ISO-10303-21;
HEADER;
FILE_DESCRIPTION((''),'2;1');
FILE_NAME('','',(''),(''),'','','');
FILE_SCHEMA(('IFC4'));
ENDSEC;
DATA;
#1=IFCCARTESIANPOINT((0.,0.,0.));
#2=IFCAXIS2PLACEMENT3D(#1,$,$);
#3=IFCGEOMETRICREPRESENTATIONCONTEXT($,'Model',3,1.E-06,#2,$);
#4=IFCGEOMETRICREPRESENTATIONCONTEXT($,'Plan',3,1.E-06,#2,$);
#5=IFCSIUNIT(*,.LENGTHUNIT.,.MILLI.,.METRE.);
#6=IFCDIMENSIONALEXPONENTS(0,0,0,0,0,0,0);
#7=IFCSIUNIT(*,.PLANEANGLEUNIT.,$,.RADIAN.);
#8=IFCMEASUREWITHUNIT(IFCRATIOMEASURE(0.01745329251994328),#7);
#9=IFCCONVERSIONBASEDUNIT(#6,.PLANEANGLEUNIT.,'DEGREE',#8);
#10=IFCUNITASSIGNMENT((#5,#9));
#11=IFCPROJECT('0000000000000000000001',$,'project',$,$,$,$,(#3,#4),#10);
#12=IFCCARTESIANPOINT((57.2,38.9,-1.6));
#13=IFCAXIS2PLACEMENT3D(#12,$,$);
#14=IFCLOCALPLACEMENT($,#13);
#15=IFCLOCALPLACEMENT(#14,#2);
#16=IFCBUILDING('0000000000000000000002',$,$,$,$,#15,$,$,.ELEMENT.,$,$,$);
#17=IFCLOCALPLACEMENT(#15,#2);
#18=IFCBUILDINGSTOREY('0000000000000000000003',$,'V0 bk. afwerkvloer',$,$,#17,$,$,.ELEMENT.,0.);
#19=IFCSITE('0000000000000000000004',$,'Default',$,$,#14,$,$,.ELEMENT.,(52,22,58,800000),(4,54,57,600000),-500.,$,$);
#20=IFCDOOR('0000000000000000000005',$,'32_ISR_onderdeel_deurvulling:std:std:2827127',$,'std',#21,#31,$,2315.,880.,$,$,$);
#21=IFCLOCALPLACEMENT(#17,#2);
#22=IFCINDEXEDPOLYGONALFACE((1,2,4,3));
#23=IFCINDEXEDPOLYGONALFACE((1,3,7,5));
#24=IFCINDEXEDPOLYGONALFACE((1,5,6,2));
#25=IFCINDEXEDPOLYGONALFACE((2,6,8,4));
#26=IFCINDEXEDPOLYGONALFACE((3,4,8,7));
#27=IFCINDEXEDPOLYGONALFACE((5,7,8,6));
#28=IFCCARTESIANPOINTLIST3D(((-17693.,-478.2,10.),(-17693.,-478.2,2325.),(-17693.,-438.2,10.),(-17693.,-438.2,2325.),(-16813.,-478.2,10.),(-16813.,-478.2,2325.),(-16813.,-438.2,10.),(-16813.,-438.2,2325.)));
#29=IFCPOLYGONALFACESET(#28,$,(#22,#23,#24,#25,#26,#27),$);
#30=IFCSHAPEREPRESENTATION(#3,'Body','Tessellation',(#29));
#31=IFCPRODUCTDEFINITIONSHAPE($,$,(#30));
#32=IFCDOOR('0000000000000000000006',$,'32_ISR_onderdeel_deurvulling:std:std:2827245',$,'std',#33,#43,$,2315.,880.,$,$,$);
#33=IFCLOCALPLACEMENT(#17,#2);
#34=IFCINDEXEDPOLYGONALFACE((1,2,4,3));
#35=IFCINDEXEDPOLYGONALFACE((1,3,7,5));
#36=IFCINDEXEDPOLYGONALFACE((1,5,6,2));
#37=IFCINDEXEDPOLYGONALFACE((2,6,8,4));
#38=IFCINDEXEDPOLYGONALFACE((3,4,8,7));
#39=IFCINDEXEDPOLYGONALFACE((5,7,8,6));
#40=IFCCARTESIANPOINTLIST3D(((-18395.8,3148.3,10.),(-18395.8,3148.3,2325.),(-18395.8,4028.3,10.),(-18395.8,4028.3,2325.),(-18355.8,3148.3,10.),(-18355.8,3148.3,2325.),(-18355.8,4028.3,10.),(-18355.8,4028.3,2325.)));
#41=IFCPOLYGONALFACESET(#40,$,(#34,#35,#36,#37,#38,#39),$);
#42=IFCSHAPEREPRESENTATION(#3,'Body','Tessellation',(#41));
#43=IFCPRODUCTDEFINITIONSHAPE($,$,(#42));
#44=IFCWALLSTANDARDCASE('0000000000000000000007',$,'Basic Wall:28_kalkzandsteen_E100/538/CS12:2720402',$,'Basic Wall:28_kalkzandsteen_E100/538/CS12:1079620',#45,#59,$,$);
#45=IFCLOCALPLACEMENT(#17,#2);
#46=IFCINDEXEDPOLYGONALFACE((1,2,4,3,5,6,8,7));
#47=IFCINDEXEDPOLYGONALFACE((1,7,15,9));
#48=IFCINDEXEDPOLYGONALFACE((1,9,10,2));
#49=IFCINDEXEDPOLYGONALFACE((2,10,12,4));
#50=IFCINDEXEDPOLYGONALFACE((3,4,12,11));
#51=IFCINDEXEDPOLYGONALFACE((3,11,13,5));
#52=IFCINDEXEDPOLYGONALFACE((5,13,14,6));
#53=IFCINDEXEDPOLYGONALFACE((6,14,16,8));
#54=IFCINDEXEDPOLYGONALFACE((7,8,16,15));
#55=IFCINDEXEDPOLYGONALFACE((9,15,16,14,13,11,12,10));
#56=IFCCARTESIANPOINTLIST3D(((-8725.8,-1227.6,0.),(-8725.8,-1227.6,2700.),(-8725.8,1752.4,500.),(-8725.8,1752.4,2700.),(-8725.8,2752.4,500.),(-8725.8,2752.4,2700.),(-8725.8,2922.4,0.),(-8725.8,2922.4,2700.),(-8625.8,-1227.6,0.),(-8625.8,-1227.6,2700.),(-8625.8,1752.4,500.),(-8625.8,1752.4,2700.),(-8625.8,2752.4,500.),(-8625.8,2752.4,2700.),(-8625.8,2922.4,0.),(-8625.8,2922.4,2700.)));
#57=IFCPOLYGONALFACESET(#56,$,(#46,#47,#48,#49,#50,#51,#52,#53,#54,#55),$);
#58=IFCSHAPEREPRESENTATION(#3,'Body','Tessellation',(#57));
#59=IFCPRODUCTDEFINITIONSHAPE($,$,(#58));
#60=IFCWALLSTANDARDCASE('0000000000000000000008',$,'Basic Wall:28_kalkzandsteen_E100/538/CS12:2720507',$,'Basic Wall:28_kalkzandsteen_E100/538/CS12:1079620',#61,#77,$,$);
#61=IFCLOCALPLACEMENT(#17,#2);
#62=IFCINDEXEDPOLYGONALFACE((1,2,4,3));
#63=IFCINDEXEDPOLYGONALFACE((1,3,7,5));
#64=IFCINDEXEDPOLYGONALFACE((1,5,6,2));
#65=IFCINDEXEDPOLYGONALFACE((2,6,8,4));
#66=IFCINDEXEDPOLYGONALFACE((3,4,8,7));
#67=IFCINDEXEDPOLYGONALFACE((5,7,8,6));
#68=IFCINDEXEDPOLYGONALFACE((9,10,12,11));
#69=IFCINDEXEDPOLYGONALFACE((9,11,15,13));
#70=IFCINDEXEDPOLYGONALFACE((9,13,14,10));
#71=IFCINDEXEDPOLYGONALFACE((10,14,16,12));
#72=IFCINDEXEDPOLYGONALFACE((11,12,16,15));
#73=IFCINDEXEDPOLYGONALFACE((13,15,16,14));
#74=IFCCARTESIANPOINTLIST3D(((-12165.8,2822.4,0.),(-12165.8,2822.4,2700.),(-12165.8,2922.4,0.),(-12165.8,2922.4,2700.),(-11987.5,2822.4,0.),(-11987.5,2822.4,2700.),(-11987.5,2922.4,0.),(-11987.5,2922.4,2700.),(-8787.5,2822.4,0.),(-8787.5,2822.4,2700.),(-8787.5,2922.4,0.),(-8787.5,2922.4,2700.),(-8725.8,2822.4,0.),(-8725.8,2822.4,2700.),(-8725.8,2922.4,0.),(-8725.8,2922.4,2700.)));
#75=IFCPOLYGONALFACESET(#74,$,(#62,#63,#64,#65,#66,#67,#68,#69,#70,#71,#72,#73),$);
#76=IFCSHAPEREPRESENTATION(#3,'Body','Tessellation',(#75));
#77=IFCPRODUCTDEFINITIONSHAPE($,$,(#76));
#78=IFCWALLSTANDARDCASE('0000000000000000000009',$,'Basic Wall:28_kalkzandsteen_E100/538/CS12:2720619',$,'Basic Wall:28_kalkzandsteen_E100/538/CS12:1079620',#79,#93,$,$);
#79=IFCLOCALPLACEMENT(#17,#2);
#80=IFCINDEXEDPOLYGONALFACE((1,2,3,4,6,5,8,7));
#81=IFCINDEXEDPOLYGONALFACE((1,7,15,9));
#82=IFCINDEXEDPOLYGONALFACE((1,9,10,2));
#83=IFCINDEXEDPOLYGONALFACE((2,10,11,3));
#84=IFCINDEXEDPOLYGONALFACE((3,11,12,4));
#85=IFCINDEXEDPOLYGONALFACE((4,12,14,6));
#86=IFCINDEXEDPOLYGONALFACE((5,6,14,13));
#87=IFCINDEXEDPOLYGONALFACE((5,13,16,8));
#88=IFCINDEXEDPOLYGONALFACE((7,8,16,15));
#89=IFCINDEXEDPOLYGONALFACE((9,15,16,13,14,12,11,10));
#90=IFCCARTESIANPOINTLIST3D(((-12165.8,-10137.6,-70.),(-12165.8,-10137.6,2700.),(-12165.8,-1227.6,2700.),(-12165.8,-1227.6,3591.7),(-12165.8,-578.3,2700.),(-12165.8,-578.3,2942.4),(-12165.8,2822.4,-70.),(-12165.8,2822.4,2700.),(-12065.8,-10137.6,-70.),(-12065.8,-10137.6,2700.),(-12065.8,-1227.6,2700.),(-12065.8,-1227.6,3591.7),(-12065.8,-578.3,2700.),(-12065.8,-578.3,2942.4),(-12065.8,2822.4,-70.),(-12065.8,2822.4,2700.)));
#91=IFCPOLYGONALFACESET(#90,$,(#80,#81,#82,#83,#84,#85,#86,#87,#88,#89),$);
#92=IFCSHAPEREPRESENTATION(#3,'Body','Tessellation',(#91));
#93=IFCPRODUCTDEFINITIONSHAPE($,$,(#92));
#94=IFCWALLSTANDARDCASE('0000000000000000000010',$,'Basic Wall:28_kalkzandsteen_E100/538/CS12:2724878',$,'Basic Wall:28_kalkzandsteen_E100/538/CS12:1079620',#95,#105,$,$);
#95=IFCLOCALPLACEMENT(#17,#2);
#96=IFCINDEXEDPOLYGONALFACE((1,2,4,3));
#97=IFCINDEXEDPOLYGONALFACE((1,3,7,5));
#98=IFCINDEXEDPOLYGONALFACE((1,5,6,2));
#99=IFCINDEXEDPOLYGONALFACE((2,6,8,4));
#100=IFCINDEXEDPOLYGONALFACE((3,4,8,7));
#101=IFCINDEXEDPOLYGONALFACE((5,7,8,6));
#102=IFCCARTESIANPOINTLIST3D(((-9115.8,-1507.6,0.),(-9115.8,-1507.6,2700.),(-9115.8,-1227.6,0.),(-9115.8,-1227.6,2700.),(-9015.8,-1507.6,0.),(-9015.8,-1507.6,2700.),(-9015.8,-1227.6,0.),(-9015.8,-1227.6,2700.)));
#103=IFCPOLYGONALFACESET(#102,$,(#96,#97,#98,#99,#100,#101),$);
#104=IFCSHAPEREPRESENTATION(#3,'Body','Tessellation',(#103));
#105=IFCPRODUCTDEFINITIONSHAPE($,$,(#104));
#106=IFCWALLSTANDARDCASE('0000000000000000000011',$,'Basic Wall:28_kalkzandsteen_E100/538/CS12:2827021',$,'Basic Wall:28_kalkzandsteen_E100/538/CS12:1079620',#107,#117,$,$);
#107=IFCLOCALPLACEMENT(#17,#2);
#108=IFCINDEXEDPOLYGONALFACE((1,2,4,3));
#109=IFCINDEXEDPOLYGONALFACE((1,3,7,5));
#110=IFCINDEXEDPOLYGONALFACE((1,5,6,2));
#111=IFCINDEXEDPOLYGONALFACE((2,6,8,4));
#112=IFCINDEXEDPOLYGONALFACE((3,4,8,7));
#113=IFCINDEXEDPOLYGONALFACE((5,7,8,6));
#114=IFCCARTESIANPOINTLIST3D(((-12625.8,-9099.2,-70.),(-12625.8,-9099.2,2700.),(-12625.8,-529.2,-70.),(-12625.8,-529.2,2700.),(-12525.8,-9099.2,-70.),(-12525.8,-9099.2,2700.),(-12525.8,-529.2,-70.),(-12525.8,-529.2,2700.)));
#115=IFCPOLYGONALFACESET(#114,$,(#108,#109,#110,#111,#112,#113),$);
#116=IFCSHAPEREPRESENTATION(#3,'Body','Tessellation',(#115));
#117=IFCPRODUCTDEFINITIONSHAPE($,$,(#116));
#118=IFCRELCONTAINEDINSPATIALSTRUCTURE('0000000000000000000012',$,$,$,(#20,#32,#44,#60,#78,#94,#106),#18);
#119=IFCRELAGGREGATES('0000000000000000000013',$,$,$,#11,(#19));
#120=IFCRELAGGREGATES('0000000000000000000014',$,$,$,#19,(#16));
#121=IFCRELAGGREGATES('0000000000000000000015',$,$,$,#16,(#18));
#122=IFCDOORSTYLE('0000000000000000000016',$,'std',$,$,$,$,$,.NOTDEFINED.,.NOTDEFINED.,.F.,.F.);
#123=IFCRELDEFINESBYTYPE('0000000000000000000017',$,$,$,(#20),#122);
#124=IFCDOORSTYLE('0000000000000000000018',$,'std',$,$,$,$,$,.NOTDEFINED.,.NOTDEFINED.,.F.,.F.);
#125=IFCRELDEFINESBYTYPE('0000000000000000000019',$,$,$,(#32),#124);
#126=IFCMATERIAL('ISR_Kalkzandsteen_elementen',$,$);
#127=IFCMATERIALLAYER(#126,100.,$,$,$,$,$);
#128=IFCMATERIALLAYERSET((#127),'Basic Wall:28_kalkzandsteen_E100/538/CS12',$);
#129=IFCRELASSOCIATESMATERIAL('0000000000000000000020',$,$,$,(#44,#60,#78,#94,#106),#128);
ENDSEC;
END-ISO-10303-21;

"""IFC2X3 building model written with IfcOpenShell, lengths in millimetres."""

from ifc_helpers import new_model, entity, si_unit, converted_unit, frame, frame_2d, origin, origin_2d_with_axis, place, context, project, spatial, polyline, rectangle, extrude, clip, bounded_halfspace, source, transform, mapped, material, layer, layer_set, layer_usage, type_object, type_shapes, element, save


model = new_model("IFC2X3")

# Units and contexts
model_context = context("Model", 3, precision=1e-06, world=origin())
plan_context = context("Plan", 3, precision=1e-06, world=origin())
ifc_project = project(units=[si_unit("LENGTHUNIT", "METRE", prefix="MILLI"), converted_unit("PLANEANGLEUNIT", "DEGREE", entity("IfcRatioMeasure", 0.01745329251994328), si_unit("PLANEANGLEUNIT", "RADIAN"), dimensions=[0, 0, 0, 0, 0, 0, 0])], contexts=[model_context, plan_context])

# Site, building, storey
site_placement = place(None, frame((57.2, 38.9, -1.6)))
site = spatial("IfcSite", under=ifc_project, at=site_placement, Name="Default", CompositionType="ELEMENT", RefLatitude=(52, 22, 58, 800000), RefLongitude=(4, 54, 57, 600000), RefElevation=-500.0)
building_placement = place(site_placement, origin())
building = spatial("IfcBuilding", under=site, at=building_placement, CompositionType="ELEMENT")
storey_placement = place(building_placement, origin())
storey = spatial("IfcBuildingStorey", under=building, at=storey_placement, Name="V0 bk. afwerkvloer", CompositionType="ELEMENT", Elevation=0.0)

# Doors
door_style_1 = type_object("IfcDoorStyle", Name="std", ConstructionType="NOTDEFINED", OperationType="NOTDEFINED", ParameterTakesPrecedence=False, Sizeable=False)
shared_shape_1 = source(origin(), model_context, "Body", "SweptSolid", [
    extrude(rectangle(XDim=880.0, YDim=40.0, at=origin_2d_with_axis()), frame((0.0, 34.0, 0.0)), (0.0, 0.0, 1.0), 2315.0),
])
type_shapes(door_style_1, [shared_shape_1])
door_1_placement = place(storey_placement, frame((-17253.0, -424.2, 10.0), z_axis=(0.0, 0.0, 1.0), x_axis=(-1.0, 0.0, 0.0)))
element("IfcDoor", 1, at=door_1_placement, inside=storey, type_object=door_style_1, Name="32_ISR_onderdeel_deurvulling:std:std:2827127", ObjectType="std", OverallHeight=2315.0, OverallWidth=880.0, context=model_context, shape_type="MappedRepresentation", body=[
    mapped(shared_shape_1, transform((0.0, 0.0, 0.0), scale=1.0)),
])
door_style_2 = type_object("IfcDoorStyle", Name="std", ConstructionType="NOTDEFINED", OperationType="NOTDEFINED", ParameterTakesPrecedence=False, Sizeable=False)
shared_shape_2 = source(origin(), model_context, "Body", "SweptSolid", [
    extrude(rectangle(XDim=40.0, YDim=880.0, at=origin_2d_with_axis()), frame((0.0, -34.0, 0.0), z_axis=(0.0, 0.0, 1.0), x_axis=(0.0, -1.0, 0.0)), (0.0, 0.0, 1.0), 2315.0),
])
type_shapes(door_style_2, [shared_shape_2])
door_2_placement = place(storey_placement, frame((-18341.8, 3588.3, 10.0), z_axis=(0.0, 0.0, 1.0), x_axis=(0.0, -1.0, 0.0)))
element("IfcDoor", 2, at=door_2_placement, inside=storey, type_object=door_style_2, Name="32_ISR_onderdeel_deurvulling:std:std:2827245", ObjectType="std", OverallHeight=2315.0, OverallWidth=880.0, context=model_context, shape_type="MappedRepresentation", body=[
    mapped(shared_shape_2, transform((0.0, 0.0, 0.0), scale=1.0)),
])

# Walls, openings
ifc_material_1 = material(Name="ISR_Kalkzandsteen_elementen")
ifc_layer_1 = layer(ifc_material_1, 100.0)
ifc_layer_set_1 = layer_set([ifc_layer_1], Name="Basic Wall:28_kalkzandsteen_E100/538/CS12")
ifc_layer_usage_1 = layer_usage(ifc_layer_set_1, "AXIS2", "NEGATIVE", 50.0)
wall_1_placement = place(storey_placement, frame((-8675.8, -1227.6, 0.0), z_axis=(0.0, 0.0, 1.0), x_axis=(0.0, 1.0, 0.0)))
wall_1 = element("IfcWallStandardCase", 3, at=wall_1_placement, inside=storey, material=ifc_layer_usage_1, Name="Basic Wall:28_kalkzandsteen_E100/538/CS12:2720402", ObjectType="Basic Wall:28_kalkzandsteen_E100/538/CS12:1079620", context=model_context, shape_type="SweptSolid", body=[
    extrude(rectangle(XDim=4150.0, YDim=100.0, at=frame_2d((2075.0, 0.0), x_axis=(-1.0, 0.0))), origin(), (0.0, 0.0, 1.0), 2700.0),
])
opening_1_placement = place(wall_1_placement, origin())
element("IfcOpeningElement", 4, at=opening_1_placement, cuts=wall_1, ObjectType="Opening", context=model_context, shape_type="SweptSolid", body=[
    extrude(rectangle(XDim=2200.0, YDim=1000.0, at=frame_2d((0.0, 0.0), x_axis=(0.0, 1.0))), frame((3480.0, -202.4, 1600.0), z_axis=(0.0, 1.0, 0.0), x_axis=(-1.0, 0.0, 0.0)), (0.0, 0.0, 1.0), 404.8),
])
ifc_layer_usage_2 = layer_usage(ifc_layer_set_1, "AXIS2", "NEGATIVE", 50.0)
wall_2_placement = place(storey_placement, frame((-8725.8, 2872.4, 0.0), z_axis=(0.0, 0.0, 1.0), x_axis=(-1.0, 0.0, 0.0)))
wall_2 = element("IfcWallStandardCase", 5, at=wall_2_placement, inside=storey, material=ifc_layer_usage_2, Name="Basic Wall:28_kalkzandsteen_E100/538/CS12:2720507", ObjectType="Basic Wall:28_kalkzandsteen_E100/538/CS12:1079620", context=model_context, shape_type="SweptSolid", body=[
    extrude(rectangle(XDim=3440.0, YDim=100.0, at=frame_2d((1720.0, 0.0), x_axis=(-1.0, 0.0))), origin(), (0.0, 0.0, 1.0), 2700.0),
])
opening_2_placement = place(wall_2_placement, origin())
element("IfcOpeningElement", 6, at=opening_2_placement, cuts=wall_2, ObjectType="Opening", context=model_context, shape_type="SweptSolid", body=[
    extrude(rectangle(XDim=2700.0, YDim=3200.0, at=origin_2d_with_axis()), frame((1661.7, -202.4, 1350.0), z_axis=(0.0, 1.0, 0.0), x_axis=(0.0, 0.0, 1.0)), (0.0, 0.0, 1.0), 404.8),
])

# Walls
ifc_layer_usage_3 = layer_usage(ifc_layer_set_1, "AXIS2", "NEGATIVE", 50.0)
wall_3_placement = place(storey_placement, frame((-12115.8, 2822.4, -70.0), z_axis=(0.0, 0.0, 1.0), x_axis=(0.0, -1.0, 0.0)))
element("IfcWallStandardCase", 7, at=wall_3_placement, inside=storey, material=ifc_layer_usage_3, Name="Basic Wall:28_kalkzandsteen_E100/538/CS12:2720619", ObjectType="Basic Wall:28_kalkzandsteen_E100/538/CS12:1079620", context=model_context, shape_type="Clipping", body=[
    clip(clip(clip(extrude(rectangle(XDim=12960.0, YDim=100.0, at=frame_2d((6480.0, 0.0), x_axis=(-1.0, 0.0))), origin(), (0.0, 0.0, 1.0), 3661.7), bounded_halfspace(frame((3400.7, -50.0, 3012.4), z_axis=(-0.707107, 0.0, 0.707107), x_axis=(0.0, -1.0, 0.0)), False, frame((3400.7, -50.0, 3012.4)), polyline([(0.0, 0.0), (649.3, 0.0), (649.3, 100.0), (0.0, 100.0), (0.0, 0.0)]))), bounded_halfspace(frame((0.0, -50.0, 2770.0), z_axis=(0.0, 0.0, 1.0), x_axis=(0.0, 1.0, 0.0)), False, frame((0.0, -50.0, 2770.0)), polyline([(0.0, 0.0), (3400.7, 0.0), (3400.7, 100.0), (0.0, 100.0), (0.0, 0.0)]))), bounded_halfspace(frame((4050.0, -50.0, 2770.0), z_axis=(0.0, 0.0, 1.0), x_axis=(0.0, 1.0, 0.0)), False, frame((4050.0, -50.0, 2770.0)), polyline([(0.0, 0.0), (8910.0, 0.0), (8910.0, 100.0), (3010.0, 100.0), (2910.0, 100.0), (280.0, 100.0), (180.0, 100.0), (100.0, 100.0), (0.0, 100.0), (0.0, 0.0)]))),
])
ifc_layer_usage_4 = layer_usage(ifc_layer_set_1, "AXIS2", "POSITIVE", -50.0)
wall_4_placement = place(storey_placement, frame((-9065.8, -1227.6, 0.0), z_axis=(0.0, 0.0, 1.0), x_axis=(0.0, -1.0, 0.0)))
element("IfcWallStandardCase", 8, at=wall_4_placement, inside=storey, material=ifc_layer_usage_4, Name="Basic Wall:28_kalkzandsteen_E100/538/CS12:2724878", ObjectType="Basic Wall:28_kalkzandsteen_E100/538/CS12:1079620", context=model_context, shape_type="SweptSolid", body=[
    extrude(rectangle(XDim=280.0, YDim=100.0, at=frame_2d((140.0, 0.0), x_axis=(-1.0, 0.0))), origin(), (0.0, 0.0, 1.0), 2700.0),
])
ifc_layer_usage_5 = layer_usage(ifc_layer_set_1, "AXIS2", "POSITIVE", -50.0)
wall_5_placement = place(storey_placement, frame((-12575.8, -529.2, -70.0), z_axis=(0.0, 0.0, 1.0), x_axis=(0.0, -1.0, 0.0)))
element("IfcWallStandardCase", 9, at=wall_5_placement, inside=storey, material=ifc_layer_usage_5, Name="Basic Wall:28_kalkzandsteen_E100/538/CS12:2827021", ObjectType="Basic Wall:28_kalkzandsteen_E100/538/CS12:1079620", context=model_context, shape_type="SweptSolid", body=[
    extrude(rectangle(XDim=8570.0, YDim=100.0, at=frame_2d((4285.0, 0.0), x_axis=(-1.0, 0.0))), origin(), (0.0, 0.0, 1.0), 2770.0),
])

save(model, "model.ifc")
